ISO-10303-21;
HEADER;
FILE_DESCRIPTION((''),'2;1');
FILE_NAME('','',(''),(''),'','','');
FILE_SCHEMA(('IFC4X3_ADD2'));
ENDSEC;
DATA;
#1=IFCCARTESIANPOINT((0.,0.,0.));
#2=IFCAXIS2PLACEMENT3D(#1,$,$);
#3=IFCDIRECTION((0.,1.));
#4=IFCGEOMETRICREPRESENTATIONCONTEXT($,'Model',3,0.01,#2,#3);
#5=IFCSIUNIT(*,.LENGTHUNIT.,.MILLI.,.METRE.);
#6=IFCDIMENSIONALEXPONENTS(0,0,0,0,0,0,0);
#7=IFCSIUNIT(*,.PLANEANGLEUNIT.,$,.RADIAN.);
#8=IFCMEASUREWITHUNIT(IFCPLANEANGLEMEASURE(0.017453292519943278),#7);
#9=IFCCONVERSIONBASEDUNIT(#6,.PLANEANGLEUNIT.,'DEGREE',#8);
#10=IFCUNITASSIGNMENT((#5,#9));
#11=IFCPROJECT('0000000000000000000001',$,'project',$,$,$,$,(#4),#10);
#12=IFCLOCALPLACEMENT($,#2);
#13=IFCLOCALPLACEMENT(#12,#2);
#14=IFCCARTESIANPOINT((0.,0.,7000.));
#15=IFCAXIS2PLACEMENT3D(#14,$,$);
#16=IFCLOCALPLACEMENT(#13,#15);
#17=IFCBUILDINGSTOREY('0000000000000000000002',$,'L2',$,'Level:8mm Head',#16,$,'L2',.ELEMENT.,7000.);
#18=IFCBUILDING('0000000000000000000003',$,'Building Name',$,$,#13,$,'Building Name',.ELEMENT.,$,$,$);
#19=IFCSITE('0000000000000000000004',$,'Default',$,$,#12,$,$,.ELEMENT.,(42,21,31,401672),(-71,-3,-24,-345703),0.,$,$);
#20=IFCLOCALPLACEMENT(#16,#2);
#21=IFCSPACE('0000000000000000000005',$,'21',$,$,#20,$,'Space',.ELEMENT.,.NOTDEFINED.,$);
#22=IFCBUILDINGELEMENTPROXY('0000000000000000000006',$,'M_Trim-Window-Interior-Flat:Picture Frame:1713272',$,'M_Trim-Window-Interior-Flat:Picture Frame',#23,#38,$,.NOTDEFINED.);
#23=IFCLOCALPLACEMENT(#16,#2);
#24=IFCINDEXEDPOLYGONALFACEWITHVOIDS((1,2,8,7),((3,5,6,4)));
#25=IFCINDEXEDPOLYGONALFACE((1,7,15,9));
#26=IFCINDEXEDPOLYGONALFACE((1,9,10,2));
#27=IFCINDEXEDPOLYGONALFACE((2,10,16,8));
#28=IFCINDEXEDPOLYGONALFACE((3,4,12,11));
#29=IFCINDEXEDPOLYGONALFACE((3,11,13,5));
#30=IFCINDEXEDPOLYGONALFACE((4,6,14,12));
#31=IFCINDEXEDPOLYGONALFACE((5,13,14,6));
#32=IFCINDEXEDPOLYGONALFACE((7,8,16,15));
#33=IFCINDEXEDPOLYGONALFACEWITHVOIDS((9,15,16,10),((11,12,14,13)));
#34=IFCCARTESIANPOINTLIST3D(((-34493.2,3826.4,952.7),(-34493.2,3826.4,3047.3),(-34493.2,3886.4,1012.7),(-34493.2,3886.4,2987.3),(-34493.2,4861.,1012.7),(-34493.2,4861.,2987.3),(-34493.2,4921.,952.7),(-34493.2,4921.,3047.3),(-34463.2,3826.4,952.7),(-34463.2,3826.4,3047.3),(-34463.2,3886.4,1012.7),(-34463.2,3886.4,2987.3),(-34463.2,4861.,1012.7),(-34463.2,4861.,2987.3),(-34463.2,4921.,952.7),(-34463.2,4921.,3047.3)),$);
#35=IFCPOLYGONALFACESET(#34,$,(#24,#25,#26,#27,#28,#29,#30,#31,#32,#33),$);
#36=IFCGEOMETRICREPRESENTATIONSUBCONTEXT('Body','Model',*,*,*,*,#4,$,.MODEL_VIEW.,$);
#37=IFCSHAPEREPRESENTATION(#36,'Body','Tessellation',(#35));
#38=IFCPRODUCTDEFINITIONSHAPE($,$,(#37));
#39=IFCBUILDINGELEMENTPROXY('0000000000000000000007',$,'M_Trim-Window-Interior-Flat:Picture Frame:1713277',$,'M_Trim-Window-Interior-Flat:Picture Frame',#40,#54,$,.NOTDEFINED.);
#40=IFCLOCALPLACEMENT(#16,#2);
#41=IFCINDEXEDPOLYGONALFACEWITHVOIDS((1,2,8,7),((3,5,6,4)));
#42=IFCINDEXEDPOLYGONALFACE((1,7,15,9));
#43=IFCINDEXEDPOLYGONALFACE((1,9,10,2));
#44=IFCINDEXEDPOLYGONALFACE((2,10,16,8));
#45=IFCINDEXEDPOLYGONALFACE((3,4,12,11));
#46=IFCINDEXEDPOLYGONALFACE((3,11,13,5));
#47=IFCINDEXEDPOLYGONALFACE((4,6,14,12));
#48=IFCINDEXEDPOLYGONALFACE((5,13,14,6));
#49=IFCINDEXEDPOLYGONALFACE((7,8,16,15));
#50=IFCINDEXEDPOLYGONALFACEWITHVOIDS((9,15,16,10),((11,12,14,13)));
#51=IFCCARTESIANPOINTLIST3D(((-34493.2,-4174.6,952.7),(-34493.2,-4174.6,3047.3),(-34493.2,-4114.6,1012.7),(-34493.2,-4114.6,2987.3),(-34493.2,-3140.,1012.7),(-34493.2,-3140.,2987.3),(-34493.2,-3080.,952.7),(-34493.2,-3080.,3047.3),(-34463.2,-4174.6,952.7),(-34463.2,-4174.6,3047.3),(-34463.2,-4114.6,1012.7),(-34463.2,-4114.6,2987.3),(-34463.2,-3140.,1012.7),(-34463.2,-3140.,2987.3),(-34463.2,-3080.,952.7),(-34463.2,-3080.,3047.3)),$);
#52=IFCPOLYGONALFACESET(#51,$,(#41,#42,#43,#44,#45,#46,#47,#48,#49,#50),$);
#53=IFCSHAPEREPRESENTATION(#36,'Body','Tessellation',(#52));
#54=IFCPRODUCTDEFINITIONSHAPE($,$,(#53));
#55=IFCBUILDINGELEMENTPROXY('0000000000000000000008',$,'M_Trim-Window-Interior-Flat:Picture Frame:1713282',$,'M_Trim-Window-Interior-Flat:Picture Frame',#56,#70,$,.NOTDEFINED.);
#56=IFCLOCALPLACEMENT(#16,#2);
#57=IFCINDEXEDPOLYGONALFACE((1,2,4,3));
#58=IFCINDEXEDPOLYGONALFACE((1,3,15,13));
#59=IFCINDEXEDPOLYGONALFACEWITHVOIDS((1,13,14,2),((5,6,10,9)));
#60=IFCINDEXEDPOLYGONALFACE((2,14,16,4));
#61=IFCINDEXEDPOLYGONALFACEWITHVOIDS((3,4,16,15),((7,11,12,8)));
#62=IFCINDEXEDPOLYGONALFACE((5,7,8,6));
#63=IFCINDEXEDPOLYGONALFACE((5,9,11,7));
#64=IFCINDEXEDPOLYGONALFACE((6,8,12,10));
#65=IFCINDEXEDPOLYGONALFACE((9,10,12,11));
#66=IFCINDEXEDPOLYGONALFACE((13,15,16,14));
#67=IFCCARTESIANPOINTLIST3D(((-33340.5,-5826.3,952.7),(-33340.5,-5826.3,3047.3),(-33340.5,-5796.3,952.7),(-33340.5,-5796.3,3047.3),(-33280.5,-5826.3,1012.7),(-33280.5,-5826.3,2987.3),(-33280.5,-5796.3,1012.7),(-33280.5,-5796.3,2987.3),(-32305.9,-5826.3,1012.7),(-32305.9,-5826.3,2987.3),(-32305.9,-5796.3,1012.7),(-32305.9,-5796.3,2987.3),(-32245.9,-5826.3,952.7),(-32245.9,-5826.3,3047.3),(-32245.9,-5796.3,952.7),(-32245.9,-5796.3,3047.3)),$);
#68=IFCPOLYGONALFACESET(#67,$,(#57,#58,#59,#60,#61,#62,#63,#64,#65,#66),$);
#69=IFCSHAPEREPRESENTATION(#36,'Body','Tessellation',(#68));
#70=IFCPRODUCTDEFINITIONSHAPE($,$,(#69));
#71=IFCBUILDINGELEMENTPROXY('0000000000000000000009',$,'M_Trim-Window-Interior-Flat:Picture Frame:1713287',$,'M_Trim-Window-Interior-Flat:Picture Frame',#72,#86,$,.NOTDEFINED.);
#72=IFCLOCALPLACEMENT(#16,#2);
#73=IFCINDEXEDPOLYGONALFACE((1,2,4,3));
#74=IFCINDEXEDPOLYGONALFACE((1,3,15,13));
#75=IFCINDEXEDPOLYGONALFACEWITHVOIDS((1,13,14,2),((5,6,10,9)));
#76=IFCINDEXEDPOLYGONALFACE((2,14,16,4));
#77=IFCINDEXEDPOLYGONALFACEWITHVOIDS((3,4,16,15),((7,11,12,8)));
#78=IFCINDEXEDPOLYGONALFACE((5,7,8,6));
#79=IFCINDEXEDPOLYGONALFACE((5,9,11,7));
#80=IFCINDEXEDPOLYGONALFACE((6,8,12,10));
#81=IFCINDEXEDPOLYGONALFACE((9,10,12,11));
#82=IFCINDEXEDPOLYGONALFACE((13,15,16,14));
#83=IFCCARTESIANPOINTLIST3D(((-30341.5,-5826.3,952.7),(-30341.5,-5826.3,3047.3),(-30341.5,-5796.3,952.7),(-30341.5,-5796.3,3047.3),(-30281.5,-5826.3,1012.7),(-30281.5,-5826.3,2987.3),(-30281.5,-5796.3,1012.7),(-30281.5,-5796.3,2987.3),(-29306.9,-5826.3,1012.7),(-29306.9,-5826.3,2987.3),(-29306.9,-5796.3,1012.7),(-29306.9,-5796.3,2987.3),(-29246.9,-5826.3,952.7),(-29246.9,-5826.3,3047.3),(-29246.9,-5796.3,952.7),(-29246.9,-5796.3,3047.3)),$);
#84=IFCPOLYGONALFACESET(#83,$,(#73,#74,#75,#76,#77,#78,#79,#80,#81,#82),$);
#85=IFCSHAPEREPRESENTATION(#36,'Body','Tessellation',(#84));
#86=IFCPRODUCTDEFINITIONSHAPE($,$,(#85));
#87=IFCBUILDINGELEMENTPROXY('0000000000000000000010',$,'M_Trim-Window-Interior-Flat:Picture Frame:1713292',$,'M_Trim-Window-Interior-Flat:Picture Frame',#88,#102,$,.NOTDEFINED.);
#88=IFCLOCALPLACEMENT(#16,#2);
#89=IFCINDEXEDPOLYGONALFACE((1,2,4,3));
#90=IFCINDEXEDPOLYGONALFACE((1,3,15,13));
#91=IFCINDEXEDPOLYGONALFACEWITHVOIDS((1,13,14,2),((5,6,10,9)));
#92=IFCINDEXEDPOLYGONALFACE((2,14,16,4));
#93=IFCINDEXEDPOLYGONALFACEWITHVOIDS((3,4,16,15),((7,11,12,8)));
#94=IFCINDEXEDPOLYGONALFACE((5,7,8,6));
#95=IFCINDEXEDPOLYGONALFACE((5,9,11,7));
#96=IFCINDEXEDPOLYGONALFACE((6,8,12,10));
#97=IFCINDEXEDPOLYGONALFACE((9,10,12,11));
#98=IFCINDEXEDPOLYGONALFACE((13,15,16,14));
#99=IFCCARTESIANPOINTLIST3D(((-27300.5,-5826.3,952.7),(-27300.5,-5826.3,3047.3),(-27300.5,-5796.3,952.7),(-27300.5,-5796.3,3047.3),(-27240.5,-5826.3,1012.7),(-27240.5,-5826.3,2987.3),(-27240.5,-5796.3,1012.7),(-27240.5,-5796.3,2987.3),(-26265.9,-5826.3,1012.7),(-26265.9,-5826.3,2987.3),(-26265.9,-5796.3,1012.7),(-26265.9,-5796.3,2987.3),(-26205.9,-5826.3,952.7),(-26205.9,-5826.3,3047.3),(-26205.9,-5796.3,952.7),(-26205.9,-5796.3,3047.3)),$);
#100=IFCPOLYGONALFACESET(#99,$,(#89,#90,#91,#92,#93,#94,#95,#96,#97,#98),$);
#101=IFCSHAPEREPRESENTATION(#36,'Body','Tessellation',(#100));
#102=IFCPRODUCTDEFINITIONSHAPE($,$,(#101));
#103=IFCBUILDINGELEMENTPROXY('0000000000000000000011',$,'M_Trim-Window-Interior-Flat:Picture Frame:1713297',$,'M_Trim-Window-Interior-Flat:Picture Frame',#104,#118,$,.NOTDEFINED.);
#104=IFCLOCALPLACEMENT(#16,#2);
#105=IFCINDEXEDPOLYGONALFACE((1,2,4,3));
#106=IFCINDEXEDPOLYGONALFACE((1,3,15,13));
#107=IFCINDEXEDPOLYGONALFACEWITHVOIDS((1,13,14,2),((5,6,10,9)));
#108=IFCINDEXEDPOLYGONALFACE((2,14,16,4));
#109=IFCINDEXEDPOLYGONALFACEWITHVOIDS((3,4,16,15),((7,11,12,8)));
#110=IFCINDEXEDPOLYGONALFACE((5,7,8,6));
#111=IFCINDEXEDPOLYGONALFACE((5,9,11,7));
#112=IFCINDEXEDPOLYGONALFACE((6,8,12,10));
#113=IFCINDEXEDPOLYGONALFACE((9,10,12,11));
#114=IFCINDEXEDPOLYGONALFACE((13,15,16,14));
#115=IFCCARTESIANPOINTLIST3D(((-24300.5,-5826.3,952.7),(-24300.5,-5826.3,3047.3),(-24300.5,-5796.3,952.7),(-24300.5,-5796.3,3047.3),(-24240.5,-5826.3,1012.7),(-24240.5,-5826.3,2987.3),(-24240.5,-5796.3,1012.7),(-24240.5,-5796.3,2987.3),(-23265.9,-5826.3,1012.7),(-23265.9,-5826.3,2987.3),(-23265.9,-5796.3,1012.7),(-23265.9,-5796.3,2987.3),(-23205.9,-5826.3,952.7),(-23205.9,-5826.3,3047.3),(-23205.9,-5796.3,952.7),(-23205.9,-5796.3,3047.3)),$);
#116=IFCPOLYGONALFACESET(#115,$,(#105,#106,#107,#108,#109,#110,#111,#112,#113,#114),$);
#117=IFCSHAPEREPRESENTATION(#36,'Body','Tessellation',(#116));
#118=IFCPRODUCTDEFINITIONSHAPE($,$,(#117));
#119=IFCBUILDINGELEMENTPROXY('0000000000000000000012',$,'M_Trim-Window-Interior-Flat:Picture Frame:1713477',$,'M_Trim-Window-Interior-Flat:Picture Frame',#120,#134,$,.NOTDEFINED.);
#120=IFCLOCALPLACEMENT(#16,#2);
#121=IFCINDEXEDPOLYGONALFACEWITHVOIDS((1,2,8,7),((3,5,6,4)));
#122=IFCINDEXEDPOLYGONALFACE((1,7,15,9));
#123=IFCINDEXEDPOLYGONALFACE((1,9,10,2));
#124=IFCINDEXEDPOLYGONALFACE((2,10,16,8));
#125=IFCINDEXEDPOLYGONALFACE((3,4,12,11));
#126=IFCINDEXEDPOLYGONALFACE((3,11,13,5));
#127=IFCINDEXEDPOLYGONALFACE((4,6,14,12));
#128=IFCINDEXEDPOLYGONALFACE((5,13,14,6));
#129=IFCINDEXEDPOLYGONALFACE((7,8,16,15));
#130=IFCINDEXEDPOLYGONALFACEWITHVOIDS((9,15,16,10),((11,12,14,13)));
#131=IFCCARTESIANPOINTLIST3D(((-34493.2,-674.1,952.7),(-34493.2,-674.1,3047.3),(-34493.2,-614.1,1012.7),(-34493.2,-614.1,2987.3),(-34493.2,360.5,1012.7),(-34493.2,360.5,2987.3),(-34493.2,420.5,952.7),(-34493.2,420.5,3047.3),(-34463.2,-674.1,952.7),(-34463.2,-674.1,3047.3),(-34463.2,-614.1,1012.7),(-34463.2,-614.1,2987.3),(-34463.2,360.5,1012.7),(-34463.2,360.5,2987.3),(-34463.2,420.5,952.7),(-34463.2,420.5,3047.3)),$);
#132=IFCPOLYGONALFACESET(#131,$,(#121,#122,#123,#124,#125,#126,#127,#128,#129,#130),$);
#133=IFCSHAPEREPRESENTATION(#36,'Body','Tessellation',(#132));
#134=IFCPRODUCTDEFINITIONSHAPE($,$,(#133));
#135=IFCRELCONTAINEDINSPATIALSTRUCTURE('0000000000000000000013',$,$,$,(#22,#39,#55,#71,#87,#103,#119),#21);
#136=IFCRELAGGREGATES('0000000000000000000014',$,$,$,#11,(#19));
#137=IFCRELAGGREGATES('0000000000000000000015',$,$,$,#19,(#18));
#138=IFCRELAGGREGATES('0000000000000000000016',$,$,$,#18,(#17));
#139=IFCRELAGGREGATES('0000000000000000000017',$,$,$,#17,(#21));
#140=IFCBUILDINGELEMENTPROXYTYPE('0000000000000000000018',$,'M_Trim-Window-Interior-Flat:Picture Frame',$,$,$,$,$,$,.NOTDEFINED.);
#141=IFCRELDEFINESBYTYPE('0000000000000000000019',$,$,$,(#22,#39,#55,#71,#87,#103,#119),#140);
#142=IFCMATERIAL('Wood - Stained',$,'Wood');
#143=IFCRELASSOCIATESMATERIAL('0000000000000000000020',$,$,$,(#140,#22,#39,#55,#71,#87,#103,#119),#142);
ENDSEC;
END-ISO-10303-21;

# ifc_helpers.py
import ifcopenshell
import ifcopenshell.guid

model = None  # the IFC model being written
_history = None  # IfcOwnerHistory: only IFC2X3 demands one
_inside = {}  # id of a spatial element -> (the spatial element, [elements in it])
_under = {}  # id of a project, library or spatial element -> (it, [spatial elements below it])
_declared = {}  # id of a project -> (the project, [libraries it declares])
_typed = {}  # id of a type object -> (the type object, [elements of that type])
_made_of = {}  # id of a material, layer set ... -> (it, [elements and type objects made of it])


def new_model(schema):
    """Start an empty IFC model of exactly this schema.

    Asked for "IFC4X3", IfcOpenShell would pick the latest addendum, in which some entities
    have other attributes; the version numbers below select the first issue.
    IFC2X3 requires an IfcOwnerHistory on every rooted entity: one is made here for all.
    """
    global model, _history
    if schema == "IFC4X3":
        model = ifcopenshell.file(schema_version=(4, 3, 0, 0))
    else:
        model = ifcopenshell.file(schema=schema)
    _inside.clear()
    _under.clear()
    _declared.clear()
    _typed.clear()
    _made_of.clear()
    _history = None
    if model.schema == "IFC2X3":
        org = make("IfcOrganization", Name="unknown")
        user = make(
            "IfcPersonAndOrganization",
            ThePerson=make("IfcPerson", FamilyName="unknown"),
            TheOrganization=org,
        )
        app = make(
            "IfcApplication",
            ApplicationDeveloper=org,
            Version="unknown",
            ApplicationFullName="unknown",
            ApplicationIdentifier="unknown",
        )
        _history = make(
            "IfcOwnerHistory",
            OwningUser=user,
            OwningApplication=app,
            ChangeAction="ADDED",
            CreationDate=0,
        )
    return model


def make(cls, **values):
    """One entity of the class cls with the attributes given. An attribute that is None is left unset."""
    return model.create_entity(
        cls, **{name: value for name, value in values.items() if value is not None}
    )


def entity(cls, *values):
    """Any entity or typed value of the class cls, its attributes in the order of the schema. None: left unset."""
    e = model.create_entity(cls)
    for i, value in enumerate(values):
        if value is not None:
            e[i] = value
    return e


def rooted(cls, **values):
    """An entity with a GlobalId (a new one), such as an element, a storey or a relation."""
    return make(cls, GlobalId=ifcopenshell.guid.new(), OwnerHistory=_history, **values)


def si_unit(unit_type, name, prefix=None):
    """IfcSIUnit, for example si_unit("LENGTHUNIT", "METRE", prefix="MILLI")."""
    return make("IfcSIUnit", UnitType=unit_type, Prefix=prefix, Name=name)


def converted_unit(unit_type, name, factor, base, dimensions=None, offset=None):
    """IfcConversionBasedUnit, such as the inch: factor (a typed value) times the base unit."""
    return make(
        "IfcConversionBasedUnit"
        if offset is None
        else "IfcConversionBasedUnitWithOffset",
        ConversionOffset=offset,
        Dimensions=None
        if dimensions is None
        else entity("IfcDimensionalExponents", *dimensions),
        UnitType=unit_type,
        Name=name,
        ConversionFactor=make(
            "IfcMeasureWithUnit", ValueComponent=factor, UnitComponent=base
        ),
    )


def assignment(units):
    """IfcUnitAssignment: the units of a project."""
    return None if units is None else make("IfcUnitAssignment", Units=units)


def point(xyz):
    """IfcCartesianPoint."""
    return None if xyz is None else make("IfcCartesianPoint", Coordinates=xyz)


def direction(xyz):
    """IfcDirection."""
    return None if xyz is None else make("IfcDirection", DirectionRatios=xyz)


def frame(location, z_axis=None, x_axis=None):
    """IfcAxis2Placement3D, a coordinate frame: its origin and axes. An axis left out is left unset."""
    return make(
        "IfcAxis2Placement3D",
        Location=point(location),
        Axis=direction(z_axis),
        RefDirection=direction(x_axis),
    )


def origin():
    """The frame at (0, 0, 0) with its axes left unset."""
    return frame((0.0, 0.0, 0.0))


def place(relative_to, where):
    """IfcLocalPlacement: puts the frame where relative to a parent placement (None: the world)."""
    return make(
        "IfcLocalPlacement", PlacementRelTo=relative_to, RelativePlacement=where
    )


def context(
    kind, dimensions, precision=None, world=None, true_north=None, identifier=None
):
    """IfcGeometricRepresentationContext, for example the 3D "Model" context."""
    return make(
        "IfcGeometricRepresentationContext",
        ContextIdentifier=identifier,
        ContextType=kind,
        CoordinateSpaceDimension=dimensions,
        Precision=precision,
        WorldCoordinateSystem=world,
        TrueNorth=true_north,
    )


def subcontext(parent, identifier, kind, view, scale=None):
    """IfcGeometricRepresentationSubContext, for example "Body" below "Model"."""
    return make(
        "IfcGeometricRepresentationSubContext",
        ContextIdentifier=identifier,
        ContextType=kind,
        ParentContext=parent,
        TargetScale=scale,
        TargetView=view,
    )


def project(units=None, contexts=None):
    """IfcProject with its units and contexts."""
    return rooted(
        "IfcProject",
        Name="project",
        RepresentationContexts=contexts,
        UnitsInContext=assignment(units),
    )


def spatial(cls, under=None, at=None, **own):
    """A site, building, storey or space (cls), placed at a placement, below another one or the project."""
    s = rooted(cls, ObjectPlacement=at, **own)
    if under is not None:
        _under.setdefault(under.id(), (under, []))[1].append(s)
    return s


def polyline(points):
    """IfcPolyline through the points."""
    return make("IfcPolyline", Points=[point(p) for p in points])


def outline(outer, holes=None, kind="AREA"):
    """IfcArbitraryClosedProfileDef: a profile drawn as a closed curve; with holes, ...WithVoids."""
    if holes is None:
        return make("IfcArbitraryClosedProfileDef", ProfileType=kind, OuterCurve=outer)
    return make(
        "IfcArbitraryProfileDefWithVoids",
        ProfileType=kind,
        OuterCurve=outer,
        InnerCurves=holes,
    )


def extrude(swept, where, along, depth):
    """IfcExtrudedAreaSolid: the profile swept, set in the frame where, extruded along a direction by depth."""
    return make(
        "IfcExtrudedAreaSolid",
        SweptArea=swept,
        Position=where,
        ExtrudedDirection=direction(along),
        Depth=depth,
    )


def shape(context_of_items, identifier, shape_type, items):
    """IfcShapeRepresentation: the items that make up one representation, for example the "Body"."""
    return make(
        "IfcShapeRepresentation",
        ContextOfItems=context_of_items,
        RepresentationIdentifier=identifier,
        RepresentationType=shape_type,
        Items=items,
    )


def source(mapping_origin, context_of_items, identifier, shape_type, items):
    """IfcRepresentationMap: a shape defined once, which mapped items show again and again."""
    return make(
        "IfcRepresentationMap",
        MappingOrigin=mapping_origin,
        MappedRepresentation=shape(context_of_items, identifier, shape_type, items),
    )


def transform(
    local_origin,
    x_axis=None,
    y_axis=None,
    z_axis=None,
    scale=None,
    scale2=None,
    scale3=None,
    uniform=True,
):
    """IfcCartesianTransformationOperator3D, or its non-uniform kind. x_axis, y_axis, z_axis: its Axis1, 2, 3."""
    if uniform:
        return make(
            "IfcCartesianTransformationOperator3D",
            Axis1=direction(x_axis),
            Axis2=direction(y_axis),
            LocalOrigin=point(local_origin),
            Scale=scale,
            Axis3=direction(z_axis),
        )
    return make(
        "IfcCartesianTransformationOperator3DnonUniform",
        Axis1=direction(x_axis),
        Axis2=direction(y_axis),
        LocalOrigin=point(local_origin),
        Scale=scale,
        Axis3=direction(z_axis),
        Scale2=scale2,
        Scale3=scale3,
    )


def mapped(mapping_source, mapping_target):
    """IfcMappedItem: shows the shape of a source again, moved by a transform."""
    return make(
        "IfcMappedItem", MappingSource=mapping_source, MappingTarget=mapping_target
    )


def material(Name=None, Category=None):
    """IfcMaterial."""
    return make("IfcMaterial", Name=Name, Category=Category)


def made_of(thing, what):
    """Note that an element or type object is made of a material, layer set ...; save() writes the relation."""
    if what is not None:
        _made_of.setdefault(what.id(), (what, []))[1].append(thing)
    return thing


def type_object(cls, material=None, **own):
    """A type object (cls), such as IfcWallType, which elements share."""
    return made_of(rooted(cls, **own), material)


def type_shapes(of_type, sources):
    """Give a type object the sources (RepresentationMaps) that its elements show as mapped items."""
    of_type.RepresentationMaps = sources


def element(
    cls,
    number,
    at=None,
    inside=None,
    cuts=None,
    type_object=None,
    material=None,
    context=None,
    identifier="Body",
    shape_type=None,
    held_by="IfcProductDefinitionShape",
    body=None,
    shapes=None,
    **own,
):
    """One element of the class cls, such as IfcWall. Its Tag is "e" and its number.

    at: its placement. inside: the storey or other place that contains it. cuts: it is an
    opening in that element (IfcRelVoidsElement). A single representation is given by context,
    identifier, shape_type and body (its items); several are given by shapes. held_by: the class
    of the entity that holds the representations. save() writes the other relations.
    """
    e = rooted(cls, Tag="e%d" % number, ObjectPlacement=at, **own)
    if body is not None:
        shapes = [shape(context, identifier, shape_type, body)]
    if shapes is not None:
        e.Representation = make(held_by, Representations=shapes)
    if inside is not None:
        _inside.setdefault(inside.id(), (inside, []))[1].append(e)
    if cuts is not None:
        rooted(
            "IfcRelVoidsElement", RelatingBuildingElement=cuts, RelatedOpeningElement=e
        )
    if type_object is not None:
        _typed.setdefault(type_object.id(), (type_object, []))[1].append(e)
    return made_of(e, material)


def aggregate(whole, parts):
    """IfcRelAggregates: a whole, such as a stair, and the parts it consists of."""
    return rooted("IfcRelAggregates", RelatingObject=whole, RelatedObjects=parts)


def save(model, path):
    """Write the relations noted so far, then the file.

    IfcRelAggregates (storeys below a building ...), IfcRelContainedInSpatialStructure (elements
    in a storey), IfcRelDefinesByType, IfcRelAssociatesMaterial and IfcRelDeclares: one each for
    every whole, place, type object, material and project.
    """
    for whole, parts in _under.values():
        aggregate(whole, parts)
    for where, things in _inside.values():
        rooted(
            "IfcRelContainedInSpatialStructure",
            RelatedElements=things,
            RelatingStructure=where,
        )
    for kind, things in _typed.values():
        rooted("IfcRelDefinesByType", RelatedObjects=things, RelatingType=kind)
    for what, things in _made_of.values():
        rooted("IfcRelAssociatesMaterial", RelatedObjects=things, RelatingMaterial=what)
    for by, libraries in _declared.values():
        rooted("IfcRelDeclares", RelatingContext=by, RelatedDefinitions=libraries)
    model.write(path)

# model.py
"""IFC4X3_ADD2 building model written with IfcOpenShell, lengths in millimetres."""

from ifc_helpers import new_model, entity, si_unit, converted_unit, direction, frame, origin, place, context, subcontext, project, spatial, polyline, outline, extrude, source, transform, mapped, material, type_object, type_shapes, element, save


model = new_model("IFC4X3_ADD2")

# Units and contexts
model_context = context("Model", 3, precision=0.01, world=origin(), true_north=direction((0.0, 1.0)))
body_context = subcontext(model_context, "Body", "Model", "MODEL_VIEW")
ifc_project = project(units=[si_unit("LENGTHUNIT", "METRE", prefix="MILLI"), converted_unit("PLANEANGLEUNIT", "DEGREE", entity("IfcPlaneAngleMeasure", 0.017453292519943278), si_unit("PLANEANGLEUNIT", "RADIAN"), dimensions=[0, 0, 0, 0, 0, 0, 0])], contexts=[model_context])

# Site, building, storey
site_placement = place(None, origin())
site = spatial("IfcSite", under=ifc_project, at=site_placement, Name="Default", CompositionType="ELEMENT", RefLatitude=(42, 21, 31, 401672), RefLongitude=(-71, -3, -24, -345703), RefElevation=0.0)
building_placement = place(site_placement, origin())
building = spatial("IfcBuilding", under=site, at=building_placement, Name="Building Name", LongName="Building Name", CompositionType="ELEMENT")
storey_placement = place(building_placement, frame((0.0, 0.0, 7000.0)))
storey = spatial("IfcBuildingStorey", under=building, at=storey_placement, Name="L2", ObjectType="Level:8mm Head", LongName="L2", CompositionType="ELEMENT", Elevation=7000.0)

# Shared definitions
ifc_material_1 = material(Name="Wood - Stained", Category="Wood")

# Shared definitions
space_placement = place(storey_placement, origin())
space = spatial("IfcSpace", under=storey, at=space_placement, Name="21", LongName="Space", CompositionType="ELEMENT", PredefinedType="NOTDEFINED")

# Building element proxies
building_element_proxy_type_1 = type_object("IfcBuildingElementProxyType", Name="M_Trim-Window-Interior-Flat:Picture Frame", PredefinedType="NOTDEFINED", material=ifc_material_1)
shared_shape_1 = source(origin(), body_context, "Body", "SweptSolid", [
    extrude(outline(polyline([(-547.3, -1047.3), (547.3, -1047.3), (547.3, 1047.3), (-547.3, 1047.3), (-547.3, -1047.3)]), holes=[polyline([(-487.3, -987.3), (-487.3, 987.3), (487.3, 987.3), (487.3, -987.3), (-487.3, -987.3)])]), frame((0.0, -1000.0, 0.0), z_axis=(0.0, 0.0, 1.0), x_axis=(-1.0, 0.0, 0.0)), (0.0, 0.0, 1.0), 30.0),
])
type_shapes(building_element_proxy_type_1, [shared_shape_1])
for number, where, z_axis, x_axis, name in (
    (1, (-34493.2, 4373.7, 3000.0), (1.0, 0.0, 0.0), (0.0, 1.0, 0.0), "M_Trim-Window-Interior-Flat:Picture Frame:1713272"),
    (2, (-34493.2, -3627.3, 3000.0), (1.0, 0.0, 0.0), (0.0, 1.0, 0.0), "M_Trim-Window-Interior-Flat:Picture Frame:1713277"),
    (3, (-32793.2, -5826.3, 3000.0), (0.0, 1.0, 0.0), (-1.0, 0.0, 0.0), "M_Trim-Window-Interior-Flat:Picture Frame:1713282"),
    (4, (-29794.2, -5826.3, 3000.0), (0.0, 1.0, 0.0), (-1.0, 0.0, 0.0), "M_Trim-Window-Interior-Flat:Picture Frame:1713287"),
    (5, (-26753.2, -5826.3, 3000.0), (0.0, 1.0, 0.0), (-1.0, 0.0, 0.0), "M_Trim-Window-Interior-Flat:Picture Frame:1713292"),
    (6, (-23753.2, -5826.3, 3000.0), (0.0, 1.0, 0.0), (-1.0, 0.0, 0.0), "M_Trim-Window-Interior-Flat:Picture Frame:1713297"),
    (7, (-34493.2, -126.8, 3000.0), (1.0, 0.0, 0.0), (0.0, 1.0, 0.0), "M_Trim-Window-Interior-Flat:Picture Frame:1713477"),
):
    element("IfcBuildingElementProxy", number, at=place(space_placement, frame(where, z_axis=z_axis, x_axis=x_axis)), inside=space, type_object=building_element_proxy_type_1, material=ifc_material_1, Name=name, ObjectType="M_Trim-Window-Interior-Flat:Picture Frame", PredefinedType="NOTDEFINED", context=body_context, shape_type="MappedRepresentation", body=[
        mapped(shared_shape_1, transform((0.0, 0.0, 0.0), scale=1.0)),
    ])

save(model, "model.ifc")
